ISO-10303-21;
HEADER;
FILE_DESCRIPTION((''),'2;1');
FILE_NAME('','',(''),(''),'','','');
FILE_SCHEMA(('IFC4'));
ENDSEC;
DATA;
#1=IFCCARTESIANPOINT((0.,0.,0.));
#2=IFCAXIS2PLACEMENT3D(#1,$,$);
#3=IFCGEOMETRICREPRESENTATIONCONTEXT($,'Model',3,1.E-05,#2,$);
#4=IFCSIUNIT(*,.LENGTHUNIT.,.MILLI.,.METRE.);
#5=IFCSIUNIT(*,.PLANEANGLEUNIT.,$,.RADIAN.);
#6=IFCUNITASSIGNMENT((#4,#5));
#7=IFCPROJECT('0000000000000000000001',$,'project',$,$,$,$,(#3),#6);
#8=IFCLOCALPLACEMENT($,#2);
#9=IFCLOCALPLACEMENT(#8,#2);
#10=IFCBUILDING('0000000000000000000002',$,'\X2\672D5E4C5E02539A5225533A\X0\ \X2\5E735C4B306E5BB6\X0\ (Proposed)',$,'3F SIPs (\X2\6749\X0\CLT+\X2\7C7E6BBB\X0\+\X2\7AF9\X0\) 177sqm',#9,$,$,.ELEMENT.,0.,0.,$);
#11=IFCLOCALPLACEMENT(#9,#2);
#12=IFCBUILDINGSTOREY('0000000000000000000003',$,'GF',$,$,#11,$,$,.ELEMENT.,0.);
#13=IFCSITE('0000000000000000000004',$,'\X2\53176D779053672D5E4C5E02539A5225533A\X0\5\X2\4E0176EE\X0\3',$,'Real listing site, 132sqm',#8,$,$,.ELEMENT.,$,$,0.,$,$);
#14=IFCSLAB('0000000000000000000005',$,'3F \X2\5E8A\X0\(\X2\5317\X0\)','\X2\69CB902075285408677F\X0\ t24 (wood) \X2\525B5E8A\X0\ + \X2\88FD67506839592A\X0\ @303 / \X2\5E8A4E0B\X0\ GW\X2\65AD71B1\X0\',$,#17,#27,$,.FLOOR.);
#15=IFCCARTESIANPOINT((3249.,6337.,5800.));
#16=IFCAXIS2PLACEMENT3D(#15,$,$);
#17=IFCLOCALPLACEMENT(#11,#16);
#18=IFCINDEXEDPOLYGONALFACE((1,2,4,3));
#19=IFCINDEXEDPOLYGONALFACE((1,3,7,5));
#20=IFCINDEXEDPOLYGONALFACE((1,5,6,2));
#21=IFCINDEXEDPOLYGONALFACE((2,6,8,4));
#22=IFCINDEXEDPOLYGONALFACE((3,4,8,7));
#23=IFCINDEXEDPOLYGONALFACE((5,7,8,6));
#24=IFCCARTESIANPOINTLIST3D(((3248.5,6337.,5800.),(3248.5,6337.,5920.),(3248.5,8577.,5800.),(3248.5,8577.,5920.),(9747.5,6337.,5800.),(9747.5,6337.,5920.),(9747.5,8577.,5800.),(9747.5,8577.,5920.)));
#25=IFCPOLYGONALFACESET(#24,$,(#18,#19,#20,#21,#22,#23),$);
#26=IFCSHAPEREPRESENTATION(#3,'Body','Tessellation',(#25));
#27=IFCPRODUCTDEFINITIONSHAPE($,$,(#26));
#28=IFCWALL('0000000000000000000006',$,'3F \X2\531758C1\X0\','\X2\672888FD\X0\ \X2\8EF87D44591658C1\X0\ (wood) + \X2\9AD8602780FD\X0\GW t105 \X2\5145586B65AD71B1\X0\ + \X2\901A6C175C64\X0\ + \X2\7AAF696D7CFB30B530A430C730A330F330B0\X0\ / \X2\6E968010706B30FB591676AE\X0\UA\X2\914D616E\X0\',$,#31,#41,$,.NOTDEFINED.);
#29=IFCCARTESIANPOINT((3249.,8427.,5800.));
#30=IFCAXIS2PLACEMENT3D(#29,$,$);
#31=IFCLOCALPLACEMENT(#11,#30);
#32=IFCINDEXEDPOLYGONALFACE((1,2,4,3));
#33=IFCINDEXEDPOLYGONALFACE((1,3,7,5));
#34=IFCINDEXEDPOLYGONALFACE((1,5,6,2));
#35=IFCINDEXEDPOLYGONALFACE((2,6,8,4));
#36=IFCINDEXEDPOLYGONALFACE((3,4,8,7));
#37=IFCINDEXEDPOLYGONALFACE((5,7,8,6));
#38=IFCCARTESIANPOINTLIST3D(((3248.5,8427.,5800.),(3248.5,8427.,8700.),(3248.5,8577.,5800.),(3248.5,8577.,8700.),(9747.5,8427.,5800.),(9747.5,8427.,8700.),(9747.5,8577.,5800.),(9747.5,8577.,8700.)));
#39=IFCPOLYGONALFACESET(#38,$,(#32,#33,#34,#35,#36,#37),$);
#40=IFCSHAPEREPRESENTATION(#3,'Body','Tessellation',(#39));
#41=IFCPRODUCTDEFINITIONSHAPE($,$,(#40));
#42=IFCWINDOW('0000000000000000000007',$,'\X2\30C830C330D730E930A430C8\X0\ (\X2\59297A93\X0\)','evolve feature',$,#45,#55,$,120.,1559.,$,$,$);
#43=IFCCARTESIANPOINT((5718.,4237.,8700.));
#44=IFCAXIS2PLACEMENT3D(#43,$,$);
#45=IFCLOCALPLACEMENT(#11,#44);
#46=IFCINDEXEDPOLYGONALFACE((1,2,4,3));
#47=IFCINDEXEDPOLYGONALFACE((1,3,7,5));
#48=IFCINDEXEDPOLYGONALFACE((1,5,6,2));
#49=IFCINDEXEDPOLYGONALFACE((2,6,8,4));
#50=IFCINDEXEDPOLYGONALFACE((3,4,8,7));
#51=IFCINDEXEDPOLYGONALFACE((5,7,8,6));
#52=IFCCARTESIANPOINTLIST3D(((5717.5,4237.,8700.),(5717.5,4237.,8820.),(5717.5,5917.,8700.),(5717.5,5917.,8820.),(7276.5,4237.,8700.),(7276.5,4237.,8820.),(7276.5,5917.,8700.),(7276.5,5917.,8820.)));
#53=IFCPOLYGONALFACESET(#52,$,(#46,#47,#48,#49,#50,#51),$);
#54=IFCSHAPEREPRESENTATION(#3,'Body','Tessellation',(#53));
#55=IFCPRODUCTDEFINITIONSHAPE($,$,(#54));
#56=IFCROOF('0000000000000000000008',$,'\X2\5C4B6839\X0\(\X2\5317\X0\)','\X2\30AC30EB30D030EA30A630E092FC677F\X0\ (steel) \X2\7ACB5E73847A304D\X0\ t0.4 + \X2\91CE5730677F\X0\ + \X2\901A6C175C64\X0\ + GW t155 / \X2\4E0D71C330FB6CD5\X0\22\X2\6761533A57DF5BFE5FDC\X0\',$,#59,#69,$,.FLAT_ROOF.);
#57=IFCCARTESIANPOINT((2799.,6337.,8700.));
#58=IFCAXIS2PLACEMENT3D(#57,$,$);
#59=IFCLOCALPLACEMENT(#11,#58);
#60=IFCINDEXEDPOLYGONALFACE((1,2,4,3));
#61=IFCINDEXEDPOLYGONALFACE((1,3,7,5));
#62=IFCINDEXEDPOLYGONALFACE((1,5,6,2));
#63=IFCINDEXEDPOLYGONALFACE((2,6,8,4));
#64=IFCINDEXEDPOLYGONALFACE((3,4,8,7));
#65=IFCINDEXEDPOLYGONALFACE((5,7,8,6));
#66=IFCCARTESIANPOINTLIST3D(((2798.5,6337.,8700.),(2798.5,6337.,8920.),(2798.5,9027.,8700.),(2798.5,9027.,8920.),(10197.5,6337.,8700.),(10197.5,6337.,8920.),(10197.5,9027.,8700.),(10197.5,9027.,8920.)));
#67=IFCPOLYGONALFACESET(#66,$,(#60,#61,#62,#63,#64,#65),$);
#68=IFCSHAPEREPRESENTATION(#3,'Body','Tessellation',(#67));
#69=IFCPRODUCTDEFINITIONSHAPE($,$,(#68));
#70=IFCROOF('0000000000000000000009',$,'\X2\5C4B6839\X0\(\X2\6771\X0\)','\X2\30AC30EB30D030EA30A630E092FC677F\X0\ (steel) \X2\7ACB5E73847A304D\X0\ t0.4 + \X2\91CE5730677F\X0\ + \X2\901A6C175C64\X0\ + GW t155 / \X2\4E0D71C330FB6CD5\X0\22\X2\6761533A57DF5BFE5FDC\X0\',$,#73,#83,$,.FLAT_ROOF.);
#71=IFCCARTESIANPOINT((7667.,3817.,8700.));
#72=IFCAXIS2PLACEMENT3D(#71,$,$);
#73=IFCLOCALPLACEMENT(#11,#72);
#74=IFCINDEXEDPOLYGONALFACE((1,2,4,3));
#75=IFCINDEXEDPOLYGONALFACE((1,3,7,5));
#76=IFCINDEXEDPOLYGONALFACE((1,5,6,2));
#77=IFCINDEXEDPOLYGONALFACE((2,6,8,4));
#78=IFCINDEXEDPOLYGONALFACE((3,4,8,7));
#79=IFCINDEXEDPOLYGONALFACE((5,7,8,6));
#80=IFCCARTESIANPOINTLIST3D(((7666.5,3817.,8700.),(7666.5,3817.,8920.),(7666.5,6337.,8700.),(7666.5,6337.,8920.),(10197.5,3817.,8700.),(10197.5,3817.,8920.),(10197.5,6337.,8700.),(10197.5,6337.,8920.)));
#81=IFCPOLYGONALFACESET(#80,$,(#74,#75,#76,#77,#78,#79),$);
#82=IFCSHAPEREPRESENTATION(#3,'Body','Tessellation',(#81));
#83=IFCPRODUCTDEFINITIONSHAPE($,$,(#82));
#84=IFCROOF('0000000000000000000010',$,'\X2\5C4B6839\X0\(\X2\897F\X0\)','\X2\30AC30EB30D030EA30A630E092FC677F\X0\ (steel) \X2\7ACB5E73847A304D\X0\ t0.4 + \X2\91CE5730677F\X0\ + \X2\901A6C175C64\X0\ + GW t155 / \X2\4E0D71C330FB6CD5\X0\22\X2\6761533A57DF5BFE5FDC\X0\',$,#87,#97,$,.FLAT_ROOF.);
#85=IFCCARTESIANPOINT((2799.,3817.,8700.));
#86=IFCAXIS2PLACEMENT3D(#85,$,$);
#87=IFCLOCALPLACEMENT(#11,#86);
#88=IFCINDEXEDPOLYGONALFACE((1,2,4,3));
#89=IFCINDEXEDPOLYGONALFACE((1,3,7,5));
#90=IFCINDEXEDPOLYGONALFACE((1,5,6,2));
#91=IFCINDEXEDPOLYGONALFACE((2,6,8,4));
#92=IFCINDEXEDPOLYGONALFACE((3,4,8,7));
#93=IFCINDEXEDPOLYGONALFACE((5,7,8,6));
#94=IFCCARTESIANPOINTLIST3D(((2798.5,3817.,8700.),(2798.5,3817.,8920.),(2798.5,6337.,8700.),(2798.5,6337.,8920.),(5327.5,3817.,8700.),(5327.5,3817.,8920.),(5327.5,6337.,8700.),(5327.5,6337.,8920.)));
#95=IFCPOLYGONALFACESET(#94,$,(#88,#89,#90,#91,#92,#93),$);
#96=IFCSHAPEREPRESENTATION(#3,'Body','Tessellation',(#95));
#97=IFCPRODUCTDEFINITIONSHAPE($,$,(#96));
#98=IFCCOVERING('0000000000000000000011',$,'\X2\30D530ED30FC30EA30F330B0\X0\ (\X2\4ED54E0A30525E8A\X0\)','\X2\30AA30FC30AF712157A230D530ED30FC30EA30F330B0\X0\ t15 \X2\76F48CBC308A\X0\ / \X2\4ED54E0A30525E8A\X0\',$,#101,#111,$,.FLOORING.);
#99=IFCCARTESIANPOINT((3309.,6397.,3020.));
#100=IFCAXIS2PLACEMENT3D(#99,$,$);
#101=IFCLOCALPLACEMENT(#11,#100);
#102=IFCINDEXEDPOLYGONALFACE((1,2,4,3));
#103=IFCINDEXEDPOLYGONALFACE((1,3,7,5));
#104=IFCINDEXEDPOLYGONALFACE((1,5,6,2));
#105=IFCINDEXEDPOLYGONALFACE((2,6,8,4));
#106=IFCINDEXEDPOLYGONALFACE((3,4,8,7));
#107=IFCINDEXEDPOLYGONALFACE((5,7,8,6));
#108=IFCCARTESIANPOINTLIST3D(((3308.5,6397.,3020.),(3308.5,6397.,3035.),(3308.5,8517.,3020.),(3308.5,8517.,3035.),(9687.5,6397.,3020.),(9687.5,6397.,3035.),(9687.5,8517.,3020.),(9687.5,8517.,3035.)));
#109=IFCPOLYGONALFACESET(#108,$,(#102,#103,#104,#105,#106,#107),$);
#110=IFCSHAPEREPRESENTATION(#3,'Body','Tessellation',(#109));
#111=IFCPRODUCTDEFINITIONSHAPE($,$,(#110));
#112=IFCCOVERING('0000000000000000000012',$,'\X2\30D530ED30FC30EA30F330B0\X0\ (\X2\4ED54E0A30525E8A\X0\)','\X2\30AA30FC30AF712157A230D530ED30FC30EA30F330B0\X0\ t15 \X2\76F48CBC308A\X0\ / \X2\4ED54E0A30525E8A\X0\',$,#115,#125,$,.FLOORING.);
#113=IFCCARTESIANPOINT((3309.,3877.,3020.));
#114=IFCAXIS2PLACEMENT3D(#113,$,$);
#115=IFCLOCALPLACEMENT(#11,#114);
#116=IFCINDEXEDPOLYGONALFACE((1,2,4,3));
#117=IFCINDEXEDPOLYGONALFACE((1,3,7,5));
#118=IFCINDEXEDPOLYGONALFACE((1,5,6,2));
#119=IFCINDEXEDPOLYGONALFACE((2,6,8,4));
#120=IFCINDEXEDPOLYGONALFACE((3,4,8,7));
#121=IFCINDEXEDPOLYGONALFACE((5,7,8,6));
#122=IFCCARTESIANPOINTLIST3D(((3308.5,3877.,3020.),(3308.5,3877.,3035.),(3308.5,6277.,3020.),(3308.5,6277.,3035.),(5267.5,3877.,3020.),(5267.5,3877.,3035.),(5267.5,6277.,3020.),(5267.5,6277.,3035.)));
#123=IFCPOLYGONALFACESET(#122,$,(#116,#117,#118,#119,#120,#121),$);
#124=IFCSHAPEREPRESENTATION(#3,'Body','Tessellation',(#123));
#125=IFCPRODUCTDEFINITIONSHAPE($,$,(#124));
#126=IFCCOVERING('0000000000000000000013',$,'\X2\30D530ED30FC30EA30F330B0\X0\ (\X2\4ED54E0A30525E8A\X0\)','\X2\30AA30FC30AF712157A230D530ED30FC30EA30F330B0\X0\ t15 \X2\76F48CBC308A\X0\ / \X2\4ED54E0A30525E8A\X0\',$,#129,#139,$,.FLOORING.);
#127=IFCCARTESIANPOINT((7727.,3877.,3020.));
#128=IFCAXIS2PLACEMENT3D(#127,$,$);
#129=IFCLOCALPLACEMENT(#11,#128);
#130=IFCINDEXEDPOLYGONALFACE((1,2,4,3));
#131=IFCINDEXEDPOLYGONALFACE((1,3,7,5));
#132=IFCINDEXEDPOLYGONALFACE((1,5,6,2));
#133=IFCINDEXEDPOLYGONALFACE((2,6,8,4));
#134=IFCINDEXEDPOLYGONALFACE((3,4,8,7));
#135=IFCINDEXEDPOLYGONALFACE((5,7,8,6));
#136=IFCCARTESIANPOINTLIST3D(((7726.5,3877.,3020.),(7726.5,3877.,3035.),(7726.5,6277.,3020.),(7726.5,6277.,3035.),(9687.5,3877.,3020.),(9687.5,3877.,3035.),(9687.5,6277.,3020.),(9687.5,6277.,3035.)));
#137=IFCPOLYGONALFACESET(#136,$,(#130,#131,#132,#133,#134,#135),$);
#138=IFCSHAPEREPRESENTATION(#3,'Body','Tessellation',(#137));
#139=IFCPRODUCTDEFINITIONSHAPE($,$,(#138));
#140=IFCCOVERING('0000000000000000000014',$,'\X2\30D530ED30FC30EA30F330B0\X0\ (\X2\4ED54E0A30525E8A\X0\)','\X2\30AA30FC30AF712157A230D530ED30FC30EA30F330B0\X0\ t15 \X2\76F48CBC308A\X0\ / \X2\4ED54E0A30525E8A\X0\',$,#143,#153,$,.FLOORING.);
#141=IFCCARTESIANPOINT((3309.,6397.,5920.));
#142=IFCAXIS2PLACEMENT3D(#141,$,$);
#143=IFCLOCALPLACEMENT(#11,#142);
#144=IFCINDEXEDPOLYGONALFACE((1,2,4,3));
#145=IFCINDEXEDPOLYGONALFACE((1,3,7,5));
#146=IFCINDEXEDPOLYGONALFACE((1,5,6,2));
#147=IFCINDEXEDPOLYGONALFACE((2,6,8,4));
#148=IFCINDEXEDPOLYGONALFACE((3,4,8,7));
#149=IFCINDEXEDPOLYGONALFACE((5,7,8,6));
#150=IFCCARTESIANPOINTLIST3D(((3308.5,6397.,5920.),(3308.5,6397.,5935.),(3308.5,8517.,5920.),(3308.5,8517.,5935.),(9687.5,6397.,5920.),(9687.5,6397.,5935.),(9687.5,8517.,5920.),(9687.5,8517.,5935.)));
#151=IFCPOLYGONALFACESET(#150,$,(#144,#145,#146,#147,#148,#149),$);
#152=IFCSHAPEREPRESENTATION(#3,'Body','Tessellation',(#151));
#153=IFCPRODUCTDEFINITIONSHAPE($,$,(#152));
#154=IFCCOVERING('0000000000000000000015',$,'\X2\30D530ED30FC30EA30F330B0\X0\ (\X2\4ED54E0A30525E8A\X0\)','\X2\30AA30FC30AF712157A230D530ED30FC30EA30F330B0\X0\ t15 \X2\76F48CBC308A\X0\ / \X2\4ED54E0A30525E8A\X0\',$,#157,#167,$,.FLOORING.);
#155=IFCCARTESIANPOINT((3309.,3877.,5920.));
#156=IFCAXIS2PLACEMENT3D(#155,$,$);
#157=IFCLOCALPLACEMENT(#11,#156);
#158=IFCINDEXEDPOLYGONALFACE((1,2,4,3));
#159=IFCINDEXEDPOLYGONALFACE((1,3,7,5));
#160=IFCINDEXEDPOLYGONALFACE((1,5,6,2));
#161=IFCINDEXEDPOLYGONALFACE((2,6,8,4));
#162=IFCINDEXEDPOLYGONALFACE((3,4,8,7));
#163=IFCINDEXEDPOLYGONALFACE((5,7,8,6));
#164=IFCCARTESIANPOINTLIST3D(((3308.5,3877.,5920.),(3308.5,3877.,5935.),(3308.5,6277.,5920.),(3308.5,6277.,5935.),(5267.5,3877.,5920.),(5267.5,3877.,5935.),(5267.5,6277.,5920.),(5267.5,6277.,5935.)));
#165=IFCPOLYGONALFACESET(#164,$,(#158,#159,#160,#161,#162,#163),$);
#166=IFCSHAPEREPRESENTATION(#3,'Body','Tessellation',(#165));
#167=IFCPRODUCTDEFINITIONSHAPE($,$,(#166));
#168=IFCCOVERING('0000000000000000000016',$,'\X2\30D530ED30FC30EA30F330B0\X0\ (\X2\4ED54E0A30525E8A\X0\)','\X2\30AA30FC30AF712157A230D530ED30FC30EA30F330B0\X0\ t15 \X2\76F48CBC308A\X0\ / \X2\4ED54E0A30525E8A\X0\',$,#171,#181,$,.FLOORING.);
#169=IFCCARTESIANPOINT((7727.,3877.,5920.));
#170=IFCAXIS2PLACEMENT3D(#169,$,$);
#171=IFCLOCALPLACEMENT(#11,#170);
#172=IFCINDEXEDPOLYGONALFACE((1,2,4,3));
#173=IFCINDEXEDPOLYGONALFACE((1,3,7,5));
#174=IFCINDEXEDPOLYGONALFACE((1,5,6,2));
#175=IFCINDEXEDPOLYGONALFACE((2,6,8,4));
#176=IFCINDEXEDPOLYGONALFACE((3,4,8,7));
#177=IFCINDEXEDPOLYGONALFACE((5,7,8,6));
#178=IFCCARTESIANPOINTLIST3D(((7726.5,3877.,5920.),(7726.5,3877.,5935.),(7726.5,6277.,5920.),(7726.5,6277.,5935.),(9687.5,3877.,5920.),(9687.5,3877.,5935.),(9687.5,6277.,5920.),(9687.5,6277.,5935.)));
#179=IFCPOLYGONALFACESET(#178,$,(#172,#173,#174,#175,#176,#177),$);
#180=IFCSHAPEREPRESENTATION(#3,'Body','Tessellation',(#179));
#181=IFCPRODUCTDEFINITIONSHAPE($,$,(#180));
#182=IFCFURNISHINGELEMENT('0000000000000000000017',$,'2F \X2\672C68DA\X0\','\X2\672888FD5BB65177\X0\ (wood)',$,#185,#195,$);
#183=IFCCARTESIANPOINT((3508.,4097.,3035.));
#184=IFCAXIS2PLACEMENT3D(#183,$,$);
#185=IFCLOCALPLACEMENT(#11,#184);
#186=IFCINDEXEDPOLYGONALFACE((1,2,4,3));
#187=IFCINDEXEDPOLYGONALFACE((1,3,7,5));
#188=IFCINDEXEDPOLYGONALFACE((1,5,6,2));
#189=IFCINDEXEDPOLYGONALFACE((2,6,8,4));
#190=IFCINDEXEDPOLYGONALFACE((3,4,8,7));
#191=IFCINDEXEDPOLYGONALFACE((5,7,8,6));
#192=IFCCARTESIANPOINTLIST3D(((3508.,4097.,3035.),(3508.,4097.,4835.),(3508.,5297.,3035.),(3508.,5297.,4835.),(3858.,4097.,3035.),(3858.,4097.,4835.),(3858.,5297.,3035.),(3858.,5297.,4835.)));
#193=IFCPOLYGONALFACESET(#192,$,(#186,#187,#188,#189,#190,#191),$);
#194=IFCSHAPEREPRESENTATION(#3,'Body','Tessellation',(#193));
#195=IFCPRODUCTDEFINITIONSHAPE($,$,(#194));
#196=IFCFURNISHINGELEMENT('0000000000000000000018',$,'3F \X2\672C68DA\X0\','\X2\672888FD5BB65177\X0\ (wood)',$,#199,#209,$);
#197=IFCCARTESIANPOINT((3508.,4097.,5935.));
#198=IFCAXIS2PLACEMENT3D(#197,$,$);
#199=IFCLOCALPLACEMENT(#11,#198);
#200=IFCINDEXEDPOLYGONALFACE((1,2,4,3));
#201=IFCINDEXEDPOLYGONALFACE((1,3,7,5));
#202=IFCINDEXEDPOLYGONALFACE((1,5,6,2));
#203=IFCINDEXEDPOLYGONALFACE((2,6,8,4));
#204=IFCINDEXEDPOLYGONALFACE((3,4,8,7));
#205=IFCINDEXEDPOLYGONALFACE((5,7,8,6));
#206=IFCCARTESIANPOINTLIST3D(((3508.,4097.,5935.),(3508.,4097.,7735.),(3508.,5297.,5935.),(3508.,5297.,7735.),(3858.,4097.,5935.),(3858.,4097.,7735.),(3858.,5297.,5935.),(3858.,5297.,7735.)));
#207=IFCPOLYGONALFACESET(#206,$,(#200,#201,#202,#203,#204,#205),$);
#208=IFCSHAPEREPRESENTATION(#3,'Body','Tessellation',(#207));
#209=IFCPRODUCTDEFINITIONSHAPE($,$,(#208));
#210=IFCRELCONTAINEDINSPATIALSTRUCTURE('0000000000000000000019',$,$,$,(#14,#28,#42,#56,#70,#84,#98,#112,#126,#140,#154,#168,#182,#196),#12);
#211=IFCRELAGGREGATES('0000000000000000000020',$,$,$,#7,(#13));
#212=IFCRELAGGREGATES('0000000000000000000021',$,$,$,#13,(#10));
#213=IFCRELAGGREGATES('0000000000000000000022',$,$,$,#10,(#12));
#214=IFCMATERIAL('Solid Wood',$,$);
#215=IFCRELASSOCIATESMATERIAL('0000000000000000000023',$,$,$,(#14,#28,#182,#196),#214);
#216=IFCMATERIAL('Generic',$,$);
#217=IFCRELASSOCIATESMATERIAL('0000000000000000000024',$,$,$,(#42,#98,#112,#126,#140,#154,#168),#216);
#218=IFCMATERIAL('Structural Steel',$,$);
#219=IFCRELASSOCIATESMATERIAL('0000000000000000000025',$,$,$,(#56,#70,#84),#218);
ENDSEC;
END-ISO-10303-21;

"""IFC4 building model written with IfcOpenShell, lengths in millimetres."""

from ifc_helpers import new_model, si_unit, frame, frame_2d, origin, place, context, project, spatial, rectangle, extrude, material, element, save


model = new_model("IFC4")

# Units and contexts
model_context = context("Model", 3, precision=1e-05, world=origin())
ifc_project = project(units=[si_unit("LENGTHUNIT", "METRE", prefix="MILLI"), si_unit("PLANEANGLEUNIT", "RADIAN")], contexts=[model_context])

# Site, building, storey
site_placement = place(None, origin())
site = spatial("IfcSite", under=ifc_project, at=site_placement, Name="北海道札幌市厚別区5丁目3", ObjectType="Real listing site, 132sqm", CompositionType="ELEMENT", RefElevation=0.0)
building_placement = place(site_placement, origin())
building = spatial("IfcBuilding", under=site, at=building_placement, Name="札幌市厚別区 平屋の家 (Proposed)", ObjectType="3F SIPs (杉CLT+籾殻+竹) 177sqm", CompositionType="ELEMENT", ElevationOfRefHeight=0.0, ElevationOfTerrain=0.0)
storey_placement = place(building_placement, origin())
storey = spatial("IfcBuildingStorey", under=building, at=storey_placement, Name="GF", CompositionType="ELEMENT", Elevation=0.0)

# Slab
ifc_material_1 = material(Name="Solid Wood")
slab_placement = place(storey_placement, frame((3249.0, 6337.0, 5800.0)))
element("IfcSlab", 1, at=slab_placement, inside=storey, material=ifc_material_1, Name="3F 床(北)", Description="構造用合板 t24 (wood) 剛床 + 製材根太 @303 / 床下 GW断熱", PredefinedType="FLOOR", context=model_context, shape_type="SweptSolid", body=[
    extrude(rectangle(XDim=6499.0, YDim=2240.0, at=frame_2d((3249.0, 1120.0))), frame((3249.0, 6337.0, 5800.0)), (0.0, 0.0, 1.0), 120.0),
])

# Wall
wall_1_placement = place(storey_placement, frame((3249.0, 8427.0, 5800.0)))
element("IfcWall", 2, at=wall_1_placement, inside=storey, material=ifc_material_1, Name="3F 北壁", Description="木製 軸組外壁 (wood) + 高性能GW t105 充填断熱 + 通気層 + 窯業系サイディング / 準耐火・外皮UA配慮", PredefinedType="NOTDEFINED", context=model_context, shape_type="SweptSolid", body=[
    extrude(rectangle(XDim=6499.0, YDim=150.0, at=frame_2d((3249.0, 75.0))), frame((3249.0, 8427.0, 5800.0)), (0.0, 0.0, 1.0), 2900.0),
])

# Window
ifc_material_2 = material(Name="Generic")
window_1_placement = place(storey_placement, frame((5718.0, 4237.0, 8700.0)))
element("IfcWindow", 3, at=window_1_placement, inside=storey, material=ifc_material_2, Name="トップライト (天窓)", Description="evolve feature", OverallHeight=120.0, OverallWidth=1559.0, context=model_context, shape_type="SweptSolid", body=[
    extrude(rectangle(XDim=1559.0, YDim=1680.0, at=frame_2d((779.0, 840.0))), frame((5718.0, 4237.0, 8700.0)), (0.0, 0.0, 1.0), 120.0),
])

# Roofs
ifc_material_3 = material(Name="Structural Steel")
roof_1_placement = place(storey_placement, frame((2799.0, 6337.0, 8700.0)))
element("IfcRoof", 4, at=roof_1_placement, inside=storey, material=ifc_material_3, Name="屋根(北)", Description="ガルバリウム鋼板 (steel) 立平葺き t0.4 + 野地板 + 通気層 + GW t155 / 不燃・法22条区域対応", PredefinedType="FLAT_ROOF", context=model_context, shape_type="SweptSolid", body=[
    extrude(rectangle(XDim=7399.0, YDim=2690.0, at=frame_2d((3699.0, 1345.0))), frame((2799.0, 6337.0, 8700.0)), (0.0, 0.0, 1.0), 220.0),
])
roof_2_placement = place(storey_placement, frame((7667.0, 3817.0, 8700.0)))
element("IfcRoof", 5, at=roof_2_placement, inside=storey, material=ifc_material_3, Name="屋根(東)", Description="ガルバリウム鋼板 (steel) 立平葺き t0.4 + 野地板 + 通気層 + GW t155 / 不燃・法22条区域対応", PredefinedType="FLAT_ROOF", context=model_context, shape_type="SweptSolid", body=[
    extrude(rectangle(XDim=2531.0, YDim=2520.0, at=frame_2d((1265.0, 1260.0))), frame((7667.0, 3817.0, 8700.0)), (0.0, 0.0, 1.0), 220.0),
])
roof_3_placement = place(storey_placement, frame((2799.0, 3817.0, 8700.0)))
element("IfcRoof", 6, at=roof_3_placement, inside=storey, material=ifc_material_3, Name="屋根(西)", Description="ガルバリウム鋼板 (steel) 立平葺き t0.4 + 野地板 + 通気層 + GW t155 / 不燃・法22条区域対応", PredefinedType="FLAT_ROOF", context=model_context, shape_type="SweptSolid", body=[
    extrude(rectangle(XDim=2529.0, YDim=2520.0, at=frame_2d((1264.0, 1260.0))), frame((2799.0, 3817.0, 8700.0)), (0.0, 0.0, 1.0), 220.0),
])

# Coverings
covering_1_placement = place(storey_placement, frame((3309.0, 6397.0, 3020.0)))
element("IfcCovering", 7, at=covering_1_placement, inside=storey, material=ifc_material_2, Name="フローリング (仕上げ床)", Description="オーク無垢フローリング t15 直貼り / 仕上げ床", PredefinedType="FLOORING", context=model_context, shape_type="SweptSolid", body=[
    extrude(rectangle(XDim=6379.0, YDim=2120.0, at=frame_2d((3189.0, 1060.0))), frame((3309.0, 6397.0, 3020.0)), (0.0, 0.0, 1.0), 15.0),
])
covering_2_placement = place(storey_placement, frame((3309.0, 3877.0, 3020.0)))
element("IfcCovering", 8, at=covering_2_placement, inside=storey, material=ifc_material_2, Name="フローリング (仕上げ床)", Description="オーク無垢フローリング t15 直貼り / 仕上げ床", PredefinedType="FLOORING", context=model_context, shape_type="SweptSolid", body=[
    extrude(rectangle(XDim=1959.0, YDim=2400.0, at=frame_2d((979.0, 1200.0))), frame((3309.0, 3877.0, 3020.0)), (0.0, 0.0, 1.0), 15.0),
])
covering_3_placement = place(storey_placement, frame((7727.0, 3877.0, 3020.0)))
element("IfcCovering", 9, at=covering_3_placement, inside=storey, material=ifc_material_2, Name="フローリング (仕上げ床)", Description="オーク無垢フローリング t15 直貼り / 仕上げ床", PredefinedType="FLOORING", context=model_context, shape_type="SweptSolid", body=[
    extrude(rectangle(XDim=1961.0, YDim=2400.0, at=frame_2d((980.0, 1200.0))), frame((7727.0, 3877.0, 3020.0)), (0.0, 0.0, 1.0), 15.0),
])
covering_4_placement = place(storey_placement, frame((3309.0, 6397.0, 5920.0)))
element("IfcCovering", 10, at=covering_4_placement, inside=storey, material=ifc_material_2, Name="フローリング (仕上げ床)", Description="オーク無垢フローリング t15 直貼り / 仕上げ床", PredefinedType="FLOORING", context=model_context, shape_type="SweptSolid", body=[
    extrude(rectangle(XDim=6379.0, YDim=2120.0, at=frame_2d((3189.0, 1060.0))), frame((3309.0, 6397.0, 5920.0)), (0.0, 0.0, 1.0), 15.0),
])
covering_5_placement = place(storey_placement, frame((3309.0, 3877.0, 5920.0)))
element("IfcCovering", 11, at=covering_5_placement, inside=storey, material=ifc_material_2, Name="フローリング (仕上げ床)", Description="オーク無垢フローリング t15 直貼り / 仕上げ床", PredefinedType="FLOORING", context=model_context, shape_type="SweptSolid", body=[
    extrude(rectangle(XDim=1959.0, YDim=2400.0, at=frame_2d((979.0, 1200.0))), frame((3309.0, 3877.0, 5920.0)), (0.0, 0.0, 1.0), 15.0),
])
covering_6_placement = place(storey_placement, frame((7727.0, 3877.0, 5920.0)))
element("IfcCovering", 12, at=covering_6_placement, inside=storey, material=ifc_material_2, Name="フローリング (仕上げ床)", Description="オーク無垢フローリング t15 直貼り / 仕上げ床", PredefinedType="FLOORING", context=model_context, shape_type="SweptSolid", body=[
    extrude(rectangle(XDim=1961.0, YDim=2400.0, at=frame_2d((980.0, 1200.0))), frame((7727.0, 3877.0, 5920.0)), (0.0, 0.0, 1.0), 15.0),
])

# Furnishing elements
furnishing_1_placement = place(storey_placement, frame((3508.0, 4097.0, 3035.0)))
element("IfcFurnishingElement", 13, at=furnishing_1_placement, inside=storey, material=ifc_material_1, Name="2F 本棚", Description="木製家具 (wood)", context=model_context, shape_type="SweptSolid", body=[
    extrude(rectangle(XDim=350.0, YDim=1200.0, at=frame_2d((175.0, 600.0))), frame((3508.0, 4097.0, 3035.0)), (0.0, 0.0, 1.0), 1800.0),
])
furnishing_2_placement = place(storey_placement, frame((3508.0, 4097.0, 5935.0)))
element("IfcFurnishingElement", 14, at=furnishing_2_placement, inside=storey, material=ifc_material_1, Name="3F 本棚", Description="木製家具 (wood)", context=model_context, shape_type="SweptSolid", body=[
    extrude(rectangle(XDim=350.0, YDim=1200.0, at=frame_2d((175.0, 600.0))), frame((3508.0, 4097.0, 5935.0)), (0.0, 0.0, 1.0), 1800.0),
])

save(model, "model.ifc")
